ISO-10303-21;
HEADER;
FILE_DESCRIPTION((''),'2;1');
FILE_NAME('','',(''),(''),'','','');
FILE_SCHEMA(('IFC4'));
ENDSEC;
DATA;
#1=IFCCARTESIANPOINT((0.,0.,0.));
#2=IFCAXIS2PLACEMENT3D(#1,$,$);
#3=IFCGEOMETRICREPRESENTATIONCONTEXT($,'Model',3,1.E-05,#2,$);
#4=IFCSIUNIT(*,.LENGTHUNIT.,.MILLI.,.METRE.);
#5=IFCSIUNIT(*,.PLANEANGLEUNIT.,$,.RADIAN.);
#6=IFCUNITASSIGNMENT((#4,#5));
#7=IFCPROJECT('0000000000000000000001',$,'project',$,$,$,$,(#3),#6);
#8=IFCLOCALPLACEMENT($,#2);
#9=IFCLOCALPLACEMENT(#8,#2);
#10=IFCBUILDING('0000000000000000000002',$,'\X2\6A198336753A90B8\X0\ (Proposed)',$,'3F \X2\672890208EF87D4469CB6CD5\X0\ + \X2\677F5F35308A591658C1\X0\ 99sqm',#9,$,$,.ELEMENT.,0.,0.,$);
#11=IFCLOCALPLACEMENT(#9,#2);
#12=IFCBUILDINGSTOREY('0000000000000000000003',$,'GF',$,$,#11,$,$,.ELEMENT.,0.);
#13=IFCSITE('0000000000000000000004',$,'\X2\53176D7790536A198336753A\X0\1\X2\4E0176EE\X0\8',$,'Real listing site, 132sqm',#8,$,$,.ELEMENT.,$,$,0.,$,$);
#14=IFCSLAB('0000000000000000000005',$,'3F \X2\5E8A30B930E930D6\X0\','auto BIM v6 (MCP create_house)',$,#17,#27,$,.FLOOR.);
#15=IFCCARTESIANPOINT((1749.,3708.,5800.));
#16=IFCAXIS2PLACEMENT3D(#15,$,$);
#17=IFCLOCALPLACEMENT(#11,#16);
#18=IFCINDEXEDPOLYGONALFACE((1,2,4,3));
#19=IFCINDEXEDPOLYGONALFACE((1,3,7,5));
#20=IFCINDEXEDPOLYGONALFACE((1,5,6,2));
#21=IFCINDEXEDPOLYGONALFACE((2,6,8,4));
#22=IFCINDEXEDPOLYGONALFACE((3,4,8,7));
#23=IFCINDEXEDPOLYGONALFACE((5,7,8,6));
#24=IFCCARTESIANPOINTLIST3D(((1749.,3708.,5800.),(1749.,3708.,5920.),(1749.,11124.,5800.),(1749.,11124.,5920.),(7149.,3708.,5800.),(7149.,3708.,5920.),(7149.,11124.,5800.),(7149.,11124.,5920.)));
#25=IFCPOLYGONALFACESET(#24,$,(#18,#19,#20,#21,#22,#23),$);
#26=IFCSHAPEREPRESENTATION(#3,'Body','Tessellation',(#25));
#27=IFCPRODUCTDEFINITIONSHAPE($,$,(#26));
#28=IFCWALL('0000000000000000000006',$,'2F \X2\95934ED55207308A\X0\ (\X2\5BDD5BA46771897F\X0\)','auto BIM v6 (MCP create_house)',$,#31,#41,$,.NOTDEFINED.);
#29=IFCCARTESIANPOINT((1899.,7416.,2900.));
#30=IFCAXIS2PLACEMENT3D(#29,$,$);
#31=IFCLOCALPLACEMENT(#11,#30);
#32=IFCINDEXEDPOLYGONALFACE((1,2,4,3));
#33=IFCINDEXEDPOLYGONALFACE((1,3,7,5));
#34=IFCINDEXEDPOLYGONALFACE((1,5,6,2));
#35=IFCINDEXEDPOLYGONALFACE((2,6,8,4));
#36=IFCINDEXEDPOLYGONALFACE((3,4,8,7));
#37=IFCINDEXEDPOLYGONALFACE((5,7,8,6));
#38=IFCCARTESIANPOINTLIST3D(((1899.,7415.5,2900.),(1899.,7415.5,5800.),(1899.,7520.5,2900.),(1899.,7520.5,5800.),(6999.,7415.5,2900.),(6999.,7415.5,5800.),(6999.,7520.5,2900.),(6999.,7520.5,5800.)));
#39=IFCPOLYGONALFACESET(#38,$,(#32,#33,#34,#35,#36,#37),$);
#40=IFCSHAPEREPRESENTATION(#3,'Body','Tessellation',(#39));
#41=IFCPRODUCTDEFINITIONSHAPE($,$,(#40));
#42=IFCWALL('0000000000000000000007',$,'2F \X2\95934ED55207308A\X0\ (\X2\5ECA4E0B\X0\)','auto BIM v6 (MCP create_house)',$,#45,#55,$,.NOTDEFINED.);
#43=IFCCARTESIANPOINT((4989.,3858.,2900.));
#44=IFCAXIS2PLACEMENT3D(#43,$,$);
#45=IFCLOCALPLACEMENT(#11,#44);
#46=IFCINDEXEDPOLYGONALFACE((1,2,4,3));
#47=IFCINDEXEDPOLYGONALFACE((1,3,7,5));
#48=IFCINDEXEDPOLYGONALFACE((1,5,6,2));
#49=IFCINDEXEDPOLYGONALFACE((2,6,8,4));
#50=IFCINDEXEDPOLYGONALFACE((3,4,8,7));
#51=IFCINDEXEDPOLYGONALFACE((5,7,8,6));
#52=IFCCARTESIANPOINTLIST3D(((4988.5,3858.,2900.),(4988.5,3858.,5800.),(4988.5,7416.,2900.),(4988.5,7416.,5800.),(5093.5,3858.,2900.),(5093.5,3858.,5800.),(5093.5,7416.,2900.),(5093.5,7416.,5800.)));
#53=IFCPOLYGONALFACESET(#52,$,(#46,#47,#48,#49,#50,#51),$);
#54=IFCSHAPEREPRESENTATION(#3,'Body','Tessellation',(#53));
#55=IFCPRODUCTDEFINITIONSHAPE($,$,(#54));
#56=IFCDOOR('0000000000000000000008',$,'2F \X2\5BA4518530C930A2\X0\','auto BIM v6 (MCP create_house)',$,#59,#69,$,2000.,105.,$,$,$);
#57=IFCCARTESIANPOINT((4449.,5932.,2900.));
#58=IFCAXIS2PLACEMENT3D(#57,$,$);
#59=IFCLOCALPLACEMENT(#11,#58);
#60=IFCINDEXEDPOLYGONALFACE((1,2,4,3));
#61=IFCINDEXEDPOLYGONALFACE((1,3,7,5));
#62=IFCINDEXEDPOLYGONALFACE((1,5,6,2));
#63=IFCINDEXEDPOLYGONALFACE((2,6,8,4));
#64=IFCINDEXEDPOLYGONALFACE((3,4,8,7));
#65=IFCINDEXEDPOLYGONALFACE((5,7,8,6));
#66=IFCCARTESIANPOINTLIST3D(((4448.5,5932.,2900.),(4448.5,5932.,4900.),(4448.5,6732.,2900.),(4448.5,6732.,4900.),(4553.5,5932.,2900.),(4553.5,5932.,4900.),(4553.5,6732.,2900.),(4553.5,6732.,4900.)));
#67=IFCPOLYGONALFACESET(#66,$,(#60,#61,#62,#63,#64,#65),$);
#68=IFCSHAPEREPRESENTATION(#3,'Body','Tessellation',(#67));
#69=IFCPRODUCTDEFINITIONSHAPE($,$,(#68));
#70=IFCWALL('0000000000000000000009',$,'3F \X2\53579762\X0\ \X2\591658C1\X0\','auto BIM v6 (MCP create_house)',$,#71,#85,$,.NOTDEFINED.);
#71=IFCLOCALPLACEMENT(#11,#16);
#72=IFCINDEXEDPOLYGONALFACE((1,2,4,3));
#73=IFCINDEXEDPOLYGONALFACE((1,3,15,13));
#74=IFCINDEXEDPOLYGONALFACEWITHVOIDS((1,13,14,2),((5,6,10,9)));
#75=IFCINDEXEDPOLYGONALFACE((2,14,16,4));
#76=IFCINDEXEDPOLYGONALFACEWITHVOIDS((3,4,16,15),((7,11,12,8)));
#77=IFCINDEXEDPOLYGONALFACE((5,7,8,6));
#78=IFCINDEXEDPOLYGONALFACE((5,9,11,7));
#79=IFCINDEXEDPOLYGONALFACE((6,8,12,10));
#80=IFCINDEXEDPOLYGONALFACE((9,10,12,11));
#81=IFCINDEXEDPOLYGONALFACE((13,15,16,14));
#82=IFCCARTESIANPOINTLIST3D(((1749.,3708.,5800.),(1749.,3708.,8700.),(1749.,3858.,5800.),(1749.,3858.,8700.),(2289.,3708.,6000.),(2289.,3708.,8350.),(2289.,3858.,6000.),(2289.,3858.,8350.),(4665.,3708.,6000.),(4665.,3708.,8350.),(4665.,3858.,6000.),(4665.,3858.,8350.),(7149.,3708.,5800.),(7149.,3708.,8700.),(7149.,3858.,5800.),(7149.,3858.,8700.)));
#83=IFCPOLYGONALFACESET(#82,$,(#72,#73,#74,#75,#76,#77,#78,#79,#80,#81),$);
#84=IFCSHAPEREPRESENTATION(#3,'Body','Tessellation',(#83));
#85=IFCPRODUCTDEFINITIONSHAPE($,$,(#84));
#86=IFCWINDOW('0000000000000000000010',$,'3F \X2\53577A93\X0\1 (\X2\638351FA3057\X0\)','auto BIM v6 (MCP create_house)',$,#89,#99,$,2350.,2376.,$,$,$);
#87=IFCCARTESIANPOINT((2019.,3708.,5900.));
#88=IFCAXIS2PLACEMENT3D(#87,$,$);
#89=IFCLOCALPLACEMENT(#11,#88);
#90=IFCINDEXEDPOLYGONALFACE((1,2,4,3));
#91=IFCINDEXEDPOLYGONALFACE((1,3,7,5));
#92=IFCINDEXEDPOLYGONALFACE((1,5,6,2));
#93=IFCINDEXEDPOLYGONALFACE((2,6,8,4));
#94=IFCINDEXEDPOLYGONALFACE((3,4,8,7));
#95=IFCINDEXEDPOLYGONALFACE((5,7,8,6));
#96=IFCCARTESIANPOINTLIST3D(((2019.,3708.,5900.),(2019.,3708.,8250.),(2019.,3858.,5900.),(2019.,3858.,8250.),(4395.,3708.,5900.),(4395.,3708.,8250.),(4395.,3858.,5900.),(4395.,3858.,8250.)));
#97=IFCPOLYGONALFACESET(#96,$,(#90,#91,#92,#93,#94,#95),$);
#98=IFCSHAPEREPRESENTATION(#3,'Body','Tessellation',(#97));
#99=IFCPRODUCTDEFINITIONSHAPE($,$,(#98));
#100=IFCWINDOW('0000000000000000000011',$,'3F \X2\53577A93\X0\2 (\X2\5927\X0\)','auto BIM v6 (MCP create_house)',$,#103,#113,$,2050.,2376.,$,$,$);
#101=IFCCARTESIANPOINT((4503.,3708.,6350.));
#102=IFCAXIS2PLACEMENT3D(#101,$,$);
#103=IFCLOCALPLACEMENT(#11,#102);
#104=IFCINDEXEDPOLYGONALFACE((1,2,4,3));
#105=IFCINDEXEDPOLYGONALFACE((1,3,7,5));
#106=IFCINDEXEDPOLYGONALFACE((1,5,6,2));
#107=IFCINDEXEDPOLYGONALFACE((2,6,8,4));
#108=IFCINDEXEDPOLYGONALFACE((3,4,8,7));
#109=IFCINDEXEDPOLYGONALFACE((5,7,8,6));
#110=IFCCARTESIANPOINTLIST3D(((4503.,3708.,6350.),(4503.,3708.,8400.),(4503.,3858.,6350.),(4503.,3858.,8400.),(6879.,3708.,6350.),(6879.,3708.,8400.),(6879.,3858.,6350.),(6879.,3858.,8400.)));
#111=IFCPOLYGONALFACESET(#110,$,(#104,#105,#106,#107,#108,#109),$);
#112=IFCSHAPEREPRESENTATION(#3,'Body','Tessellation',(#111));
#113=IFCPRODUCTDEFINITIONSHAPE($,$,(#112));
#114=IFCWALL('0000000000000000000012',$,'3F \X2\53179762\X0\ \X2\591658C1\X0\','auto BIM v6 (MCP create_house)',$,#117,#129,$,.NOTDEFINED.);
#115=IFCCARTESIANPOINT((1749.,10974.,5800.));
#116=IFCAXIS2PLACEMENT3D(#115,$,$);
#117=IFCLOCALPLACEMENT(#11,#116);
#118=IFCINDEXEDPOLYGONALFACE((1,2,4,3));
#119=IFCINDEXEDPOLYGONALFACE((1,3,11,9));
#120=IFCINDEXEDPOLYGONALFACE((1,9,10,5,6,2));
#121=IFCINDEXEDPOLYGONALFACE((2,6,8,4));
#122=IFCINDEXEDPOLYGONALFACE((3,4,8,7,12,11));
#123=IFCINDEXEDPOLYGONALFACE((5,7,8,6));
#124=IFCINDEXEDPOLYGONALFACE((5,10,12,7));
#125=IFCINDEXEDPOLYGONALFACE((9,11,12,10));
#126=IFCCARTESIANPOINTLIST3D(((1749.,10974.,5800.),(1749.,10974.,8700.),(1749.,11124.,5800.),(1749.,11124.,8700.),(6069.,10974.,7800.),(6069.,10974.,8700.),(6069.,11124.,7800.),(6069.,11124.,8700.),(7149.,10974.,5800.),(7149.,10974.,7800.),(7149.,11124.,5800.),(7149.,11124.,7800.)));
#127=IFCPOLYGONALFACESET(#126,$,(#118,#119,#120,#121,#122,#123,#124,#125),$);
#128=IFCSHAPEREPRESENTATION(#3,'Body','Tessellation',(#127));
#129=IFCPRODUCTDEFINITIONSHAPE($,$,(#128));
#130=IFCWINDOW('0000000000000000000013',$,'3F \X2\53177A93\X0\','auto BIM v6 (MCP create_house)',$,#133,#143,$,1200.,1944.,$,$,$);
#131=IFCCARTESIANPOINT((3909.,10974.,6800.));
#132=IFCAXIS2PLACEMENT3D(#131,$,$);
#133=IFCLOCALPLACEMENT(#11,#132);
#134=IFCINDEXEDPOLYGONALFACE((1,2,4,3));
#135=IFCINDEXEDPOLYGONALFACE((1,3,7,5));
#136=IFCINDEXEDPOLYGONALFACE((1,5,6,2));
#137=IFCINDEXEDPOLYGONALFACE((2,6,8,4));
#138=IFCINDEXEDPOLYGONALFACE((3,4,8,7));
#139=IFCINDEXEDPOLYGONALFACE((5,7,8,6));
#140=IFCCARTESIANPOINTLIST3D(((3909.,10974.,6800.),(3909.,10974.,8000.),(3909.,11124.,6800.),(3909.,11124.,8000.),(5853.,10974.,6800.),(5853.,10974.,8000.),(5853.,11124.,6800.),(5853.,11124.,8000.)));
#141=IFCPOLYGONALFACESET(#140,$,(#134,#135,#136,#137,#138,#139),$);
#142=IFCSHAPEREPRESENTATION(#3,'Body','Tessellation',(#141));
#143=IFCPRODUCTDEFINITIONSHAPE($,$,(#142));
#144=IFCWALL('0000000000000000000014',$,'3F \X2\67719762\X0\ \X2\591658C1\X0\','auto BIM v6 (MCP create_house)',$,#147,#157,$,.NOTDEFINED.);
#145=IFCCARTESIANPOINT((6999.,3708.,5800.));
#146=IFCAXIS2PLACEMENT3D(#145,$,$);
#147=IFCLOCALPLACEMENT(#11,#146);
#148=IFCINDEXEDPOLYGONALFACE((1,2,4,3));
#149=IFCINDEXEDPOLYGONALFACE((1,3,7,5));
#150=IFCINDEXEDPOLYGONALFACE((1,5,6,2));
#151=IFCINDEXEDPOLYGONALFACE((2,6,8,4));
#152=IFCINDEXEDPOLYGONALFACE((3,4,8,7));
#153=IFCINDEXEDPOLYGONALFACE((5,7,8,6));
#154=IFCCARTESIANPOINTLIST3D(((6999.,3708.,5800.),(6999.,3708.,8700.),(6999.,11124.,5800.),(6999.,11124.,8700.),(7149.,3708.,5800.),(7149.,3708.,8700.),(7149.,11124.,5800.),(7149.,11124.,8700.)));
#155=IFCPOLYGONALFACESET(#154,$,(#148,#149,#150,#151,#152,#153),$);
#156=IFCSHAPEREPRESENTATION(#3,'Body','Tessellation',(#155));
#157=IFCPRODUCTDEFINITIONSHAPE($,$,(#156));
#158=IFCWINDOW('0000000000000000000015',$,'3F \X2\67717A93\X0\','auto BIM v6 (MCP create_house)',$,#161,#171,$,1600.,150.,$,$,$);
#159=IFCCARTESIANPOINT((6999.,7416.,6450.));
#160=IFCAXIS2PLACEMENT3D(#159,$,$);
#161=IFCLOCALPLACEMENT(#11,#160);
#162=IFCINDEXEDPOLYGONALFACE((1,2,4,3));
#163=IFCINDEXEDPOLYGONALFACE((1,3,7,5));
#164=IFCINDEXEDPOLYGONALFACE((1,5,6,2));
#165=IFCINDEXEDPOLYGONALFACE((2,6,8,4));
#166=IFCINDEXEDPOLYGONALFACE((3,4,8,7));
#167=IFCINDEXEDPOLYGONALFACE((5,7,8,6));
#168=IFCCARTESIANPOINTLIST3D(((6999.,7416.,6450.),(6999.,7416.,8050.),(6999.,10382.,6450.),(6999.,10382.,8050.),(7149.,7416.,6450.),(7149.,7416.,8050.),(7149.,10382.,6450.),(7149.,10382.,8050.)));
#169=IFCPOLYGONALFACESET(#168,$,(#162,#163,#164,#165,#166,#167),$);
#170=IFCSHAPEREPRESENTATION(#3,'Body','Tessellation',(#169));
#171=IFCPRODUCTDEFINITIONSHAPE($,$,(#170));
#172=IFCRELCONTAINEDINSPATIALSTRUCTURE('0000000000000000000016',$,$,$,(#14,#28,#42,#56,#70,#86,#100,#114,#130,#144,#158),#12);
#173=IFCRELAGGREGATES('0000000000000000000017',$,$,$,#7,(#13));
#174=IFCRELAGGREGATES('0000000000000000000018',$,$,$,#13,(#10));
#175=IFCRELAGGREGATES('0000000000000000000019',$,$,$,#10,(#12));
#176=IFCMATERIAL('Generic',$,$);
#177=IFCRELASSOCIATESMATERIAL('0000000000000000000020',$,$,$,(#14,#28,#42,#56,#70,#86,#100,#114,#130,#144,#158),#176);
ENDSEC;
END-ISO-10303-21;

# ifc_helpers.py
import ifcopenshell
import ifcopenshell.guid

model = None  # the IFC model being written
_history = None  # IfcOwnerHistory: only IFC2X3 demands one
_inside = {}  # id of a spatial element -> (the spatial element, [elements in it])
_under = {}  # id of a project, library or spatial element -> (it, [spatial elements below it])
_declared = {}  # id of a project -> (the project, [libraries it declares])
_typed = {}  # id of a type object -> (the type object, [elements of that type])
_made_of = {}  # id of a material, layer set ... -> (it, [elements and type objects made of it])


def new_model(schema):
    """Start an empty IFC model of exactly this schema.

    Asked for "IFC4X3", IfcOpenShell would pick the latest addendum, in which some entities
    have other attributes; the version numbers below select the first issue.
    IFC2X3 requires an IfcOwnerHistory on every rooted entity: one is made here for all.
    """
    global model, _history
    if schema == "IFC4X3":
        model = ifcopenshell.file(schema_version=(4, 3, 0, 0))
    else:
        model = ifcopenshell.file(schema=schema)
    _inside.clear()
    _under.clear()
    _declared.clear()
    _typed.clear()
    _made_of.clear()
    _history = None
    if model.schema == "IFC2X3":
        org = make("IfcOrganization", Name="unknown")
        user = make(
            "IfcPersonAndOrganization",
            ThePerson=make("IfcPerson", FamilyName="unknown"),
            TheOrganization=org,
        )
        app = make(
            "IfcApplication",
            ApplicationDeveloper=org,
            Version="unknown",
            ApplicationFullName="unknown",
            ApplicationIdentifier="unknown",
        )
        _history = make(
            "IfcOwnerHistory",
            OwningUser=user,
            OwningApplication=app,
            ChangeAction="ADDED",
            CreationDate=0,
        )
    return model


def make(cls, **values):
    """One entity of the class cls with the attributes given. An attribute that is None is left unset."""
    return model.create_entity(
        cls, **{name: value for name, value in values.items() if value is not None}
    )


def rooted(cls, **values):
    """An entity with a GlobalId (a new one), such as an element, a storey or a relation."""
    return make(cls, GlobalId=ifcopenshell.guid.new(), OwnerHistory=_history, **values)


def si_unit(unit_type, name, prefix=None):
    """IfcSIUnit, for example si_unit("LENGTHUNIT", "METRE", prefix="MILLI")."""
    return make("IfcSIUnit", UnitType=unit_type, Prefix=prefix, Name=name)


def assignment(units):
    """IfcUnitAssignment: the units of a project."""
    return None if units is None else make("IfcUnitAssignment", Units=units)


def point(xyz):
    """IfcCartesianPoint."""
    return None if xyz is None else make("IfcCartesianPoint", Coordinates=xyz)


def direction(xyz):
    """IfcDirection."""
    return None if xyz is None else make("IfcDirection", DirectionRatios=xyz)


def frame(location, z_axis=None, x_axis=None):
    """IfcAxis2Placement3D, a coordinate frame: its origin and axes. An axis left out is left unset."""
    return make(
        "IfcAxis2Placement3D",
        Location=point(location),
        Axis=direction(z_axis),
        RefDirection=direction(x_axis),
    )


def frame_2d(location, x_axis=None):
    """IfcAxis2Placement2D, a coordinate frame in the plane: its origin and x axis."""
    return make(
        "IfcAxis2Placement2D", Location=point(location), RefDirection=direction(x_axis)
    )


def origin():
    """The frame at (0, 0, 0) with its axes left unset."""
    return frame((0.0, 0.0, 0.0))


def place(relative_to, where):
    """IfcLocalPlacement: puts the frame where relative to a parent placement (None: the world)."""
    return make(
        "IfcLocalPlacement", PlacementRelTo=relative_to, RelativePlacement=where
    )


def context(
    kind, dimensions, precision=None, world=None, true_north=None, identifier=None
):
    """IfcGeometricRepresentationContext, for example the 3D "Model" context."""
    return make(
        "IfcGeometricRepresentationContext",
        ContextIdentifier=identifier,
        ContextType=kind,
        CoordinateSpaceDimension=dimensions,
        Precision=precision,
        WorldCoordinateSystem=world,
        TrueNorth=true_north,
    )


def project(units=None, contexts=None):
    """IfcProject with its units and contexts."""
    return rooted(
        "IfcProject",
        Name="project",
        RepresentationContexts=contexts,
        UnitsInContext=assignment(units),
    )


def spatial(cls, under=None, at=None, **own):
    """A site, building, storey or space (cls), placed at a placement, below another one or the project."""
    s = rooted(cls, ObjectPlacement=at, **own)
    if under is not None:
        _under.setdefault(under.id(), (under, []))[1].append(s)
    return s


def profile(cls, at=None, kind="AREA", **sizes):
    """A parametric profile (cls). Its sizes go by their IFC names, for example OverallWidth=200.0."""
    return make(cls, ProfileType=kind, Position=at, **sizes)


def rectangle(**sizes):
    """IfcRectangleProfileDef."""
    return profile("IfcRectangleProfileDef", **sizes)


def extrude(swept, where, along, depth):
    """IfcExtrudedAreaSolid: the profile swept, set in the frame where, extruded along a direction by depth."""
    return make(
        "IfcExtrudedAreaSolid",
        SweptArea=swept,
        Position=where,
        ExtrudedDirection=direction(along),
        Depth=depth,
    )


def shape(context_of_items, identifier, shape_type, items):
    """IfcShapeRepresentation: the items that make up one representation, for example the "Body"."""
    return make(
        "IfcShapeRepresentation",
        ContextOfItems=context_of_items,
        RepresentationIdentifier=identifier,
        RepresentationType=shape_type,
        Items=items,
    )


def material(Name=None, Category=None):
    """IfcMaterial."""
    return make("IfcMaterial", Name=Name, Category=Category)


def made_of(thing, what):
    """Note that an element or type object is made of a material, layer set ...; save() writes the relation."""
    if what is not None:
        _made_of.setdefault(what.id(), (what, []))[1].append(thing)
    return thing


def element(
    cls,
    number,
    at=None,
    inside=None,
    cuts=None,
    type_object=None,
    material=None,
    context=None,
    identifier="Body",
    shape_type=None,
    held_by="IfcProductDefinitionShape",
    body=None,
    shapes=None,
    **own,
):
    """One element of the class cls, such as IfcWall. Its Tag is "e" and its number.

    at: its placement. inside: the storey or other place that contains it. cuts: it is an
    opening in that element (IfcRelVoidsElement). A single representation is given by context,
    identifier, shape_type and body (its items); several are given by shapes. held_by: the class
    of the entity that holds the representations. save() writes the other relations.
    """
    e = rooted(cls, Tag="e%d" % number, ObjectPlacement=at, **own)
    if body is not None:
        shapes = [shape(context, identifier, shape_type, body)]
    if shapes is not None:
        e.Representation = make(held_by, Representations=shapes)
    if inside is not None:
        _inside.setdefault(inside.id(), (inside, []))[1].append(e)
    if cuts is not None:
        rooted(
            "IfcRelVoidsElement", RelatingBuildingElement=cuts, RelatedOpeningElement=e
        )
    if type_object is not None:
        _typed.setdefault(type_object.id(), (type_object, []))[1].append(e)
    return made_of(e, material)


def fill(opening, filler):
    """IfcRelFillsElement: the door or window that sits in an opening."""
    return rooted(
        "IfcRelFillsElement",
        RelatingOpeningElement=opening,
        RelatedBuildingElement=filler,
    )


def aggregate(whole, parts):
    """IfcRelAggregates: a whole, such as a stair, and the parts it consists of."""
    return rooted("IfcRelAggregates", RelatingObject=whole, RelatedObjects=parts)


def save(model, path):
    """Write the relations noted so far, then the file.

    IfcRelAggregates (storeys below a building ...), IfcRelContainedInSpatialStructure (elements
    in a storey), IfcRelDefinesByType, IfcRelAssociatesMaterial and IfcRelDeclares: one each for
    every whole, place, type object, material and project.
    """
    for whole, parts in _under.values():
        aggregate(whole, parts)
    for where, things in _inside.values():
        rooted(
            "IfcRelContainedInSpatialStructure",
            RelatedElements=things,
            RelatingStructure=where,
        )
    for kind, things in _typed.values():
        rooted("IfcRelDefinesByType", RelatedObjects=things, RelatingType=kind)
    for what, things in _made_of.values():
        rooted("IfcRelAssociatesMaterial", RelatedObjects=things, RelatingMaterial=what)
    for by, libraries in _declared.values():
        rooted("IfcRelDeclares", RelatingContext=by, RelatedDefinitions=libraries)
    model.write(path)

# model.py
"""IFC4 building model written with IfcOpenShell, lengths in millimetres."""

from ifc_helpers import new_model, si_unit, frame, frame_2d, origin, place, context, project, spatial, rectangle, extrude, material, element, fill, save


model = new_model("IFC4")

# Units and contexts
model_context = context("Model", 3, precision=1e-05, world=origin())
ifc_project = project(units=[si_unit("LENGTHUNIT", "METRE", prefix="MILLI"), si_unit("PLANEANGLEUNIT", "RADIAN")], contexts=[model_context])

# Site, building, storey
site_placement = place(None, origin())
site = spatial("IfcSite", under=ifc_project, at=site_placement, Name="北海道標茶町1丁目8", ObjectType="Real listing site, 132sqm", CompositionType="ELEMENT", RefElevation=0.0)
building_placement = place(site_placement, origin())
building = spatial("IfcBuilding", under=site, at=building_placement, Name="標茶町邸 (Proposed)", ObjectType="3F 木造軸組構法 + 板張り外壁 99sqm", CompositionType="ELEMENT", ElevationOfRefHeight=0.0, ElevationOfTerrain=0.0)
storey_placement = place(building_placement, origin())
storey = spatial("IfcBuildingStorey", under=building, at=storey_placement, Name="GF", CompositionType="ELEMENT", Elevation=0.0)

# Slab
ifc_material = material(Name="Generic")
slab_placement = place(storey_placement, frame((1749.0, 3708.0, 5800.0)))
element("IfcSlab", 1, at=slab_placement, inside=storey, material=ifc_material, Name="3F 床スラブ", Description="auto BIM v6 (MCP create_house)", PredefinedType="FLOOR", context=model_context, shape_type="SweptSolid", body=[
    extrude(rectangle(XDim=5400.0, YDim=7416.0, at=frame_2d((2700.0, 3708.0))), frame((1749.0, 3708.0, 5800.0)), (0.0, 0.0, 1.0), 120.0),
])

# Walls
wall_1_placement = place(storey_placement, frame((1899.0, 7416.0, 2900.0)))
element("IfcWall", 2, at=wall_1_placement, inside=storey, material=ifc_material, Name="2F 間仕切り (寝室東西)", Description="auto BIM v6 (MCP create_house)", PredefinedType="NOTDEFINED", context=model_context, shape_type="SweptSolid", body=[
    extrude(rectangle(XDim=5100.0, YDim=105.0, at=frame_2d((2550.0, 52.0))), frame((1899.0, 7416.0, 2900.0)), (0.0, 0.0, 1.0), 2900.0),
])
wall_2_placement = place(storey_placement, frame((4989.0, 3858.0, 2900.0)))
element("IfcWall", 3, at=wall_2_placement, inside=storey, material=ifc_material, Name="2F 間仕切り (廊下)", Description="auto BIM v6 (MCP create_house)", PredefinedType="NOTDEFINED", context=model_context, shape_type="SweptSolid", body=[
    extrude(rectangle(XDim=105.0, YDim=3558.0, at=frame_2d((52.0, 1779.0))), frame((4989.0, 3858.0, 2900.0)), (0.0, 0.0, 1.0), 2900.0),
])

# Door
door_1_placement = place(storey_placement, frame((4449.0, 5932.0, 2900.0)))
element("IfcDoor", 4, at=door_1_placement, inside=storey, material=ifc_material, Name="2F 室内ドア", Description="auto BIM v6 (MCP create_house)", OverallHeight=2000.0, OverallWidth=105.0, context=model_context, shape_type="SweptSolid", body=[
    extrude(rectangle(XDim=105.0, YDim=800.0, at=frame_2d((52.0, 400.0))), frame((4449.0, 5932.0, 2900.0)), (0.0, 0.0, 1.0), 2000.0),
])

# Wall, openings, windows
wall_3_placement = place(storey_placement, frame((1749.0, 3708.0, 5800.0)))
wall_3 = element("IfcWall", 5, at=wall_3_placement, inside=storey, material=ifc_material, Name="3F 南面 外壁", Description="auto BIM v6 (MCP create_house)", PredefinedType="NOTDEFINED", context=model_context, shape_type="SweptSolid", body=[
    extrude(rectangle(XDim=5400.0, YDim=150.0, at=frame_2d((2700.0, 75.0))), frame((1749.0, 3708.0, 5800.0)), (0.0, 0.0, 1.0), 2900.0),
])
opening_1_placement = place(storey_placement, frame((2019.0, 3708.0, 5900.0)))
opening_1 = element("IfcOpeningElement", 6, at=opening_1_placement, cuts=wall_3, PredefinedType="NOTDEFINED", context=model_context, shape_type="SweptSolid", body=[
    extrude(rectangle(XDim=2376.0, YDim=150.0, at=frame_2d((1188.0, 75.0))), frame((2019.0, 3708.0, 5900.0)), (0.0, 0.0, 1.0), 2350.0),
])
opening_2_placement = place(storey_placement, frame((4503.0, 3708.0, 6350.0)))
opening_2 = element("IfcOpeningElement", 7, at=opening_2_placement, cuts=wall_3, PredefinedType="NOTDEFINED", context=model_context, shape_type="SweptSolid", body=[
    extrude(rectangle(XDim=2376.0, YDim=150.0, at=frame_2d((1188.0, 75.0))), frame((4503.0, 3708.0, 6350.0)), (0.0, 0.0, 1.0), 2050.0),
])
window_1_placement = place(storey_placement, frame((2019.0, 3708.0, 5900.0)))
window_1 = element("IfcWindow", 8, at=window_1_placement, inside=storey, material=ifc_material, Name="3F 南窓1 (掃出し)", Description="auto BIM v6 (MCP create_house)", OverallHeight=2350.0, OverallWidth=2376.0, context=model_context, shape_type="SweptSolid", body=[
    extrude(rectangle(XDim=2376.0, YDim=150.0, at=frame_2d((1188.0, 75.0))), frame((2019.0, 3708.0, 5900.0)), (0.0, 0.0, 1.0), 2350.0),
])
fill(opening_1, window_1)
window_2_placement = place(storey_placement, frame((4503.0, 3708.0, 6350.0)))
window_2 = element("IfcWindow", 9, at=window_2_placement, inside=storey, material=ifc_material, Name="3F 南窓2 (大)", Description="auto BIM v6 (MCP create_house)", OverallHeight=2050.0, OverallWidth=2376.0, context=model_context, shape_type="SweptSolid", body=[
    extrude(rectangle(XDim=2376.0, YDim=150.0, at=frame_2d((1188.0, 75.0))), frame((4503.0, 3708.0, 6350.0)), (0.0, 0.0, 1.0), 2050.0),
])
fill(opening_2, window_2)

# Walls, openings, windows
wall_4_placement = place(storey_placement, frame((1749.0, 10974.0, 5800.0)))
wall_4 = element("IfcWall", 10, at=wall_4_placement, inside=storey, material=ifc_material, Name="3F 北面 外壁", Description="auto BIM v6 (MCP create_house)", PredefinedType="NOTDEFINED", context=model_context, shape_type="SweptSolid", body=[
    extrude(rectangle(XDim=5400.0, YDim=150.0, at=frame_2d((2700.0, 75.0))), frame((1749.0, 10974.0, 5800.0)), (0.0, 0.0, 1.0), 2900.0),
])
opening_3_placement = place(storey_placement, frame((3909.0, 10974.0, 6800.0)))
opening_3 = element("IfcOpeningElement", 11, at=opening_3_placement, cuts=wall_4, PredefinedType="NOTDEFINED", context=model_context, shape_type="SweptSolid", body=[
    extrude(rectangle(XDim=1944.0, YDim=150.0, at=frame_2d((972.0, 75.0))), frame((3909.0, 10974.0, 6800.0)), (0.0, 0.0, 1.0), 1200.0),
])
window_3_placement = place(storey_placement, frame((3909.0, 10974.0, 6800.0)))
window_3 = element("IfcWindow", 12, at=window_3_placement, inside=storey, material=ifc_material, Name="3F 北窓", Description="auto BIM v6 (MCP create_house)", OverallHeight=1200.0, OverallWidth=1944.0, context=model_context, shape_type="SweptSolid", body=[
    extrude(rectangle(XDim=1944.0, YDim=150.0, at=frame_2d((972.0, 75.0))), frame((3909.0, 10974.0, 6800.0)), (0.0, 0.0, 1.0), 1200.0),
])
fill(opening_3, window_3)
wall_5_placement = place(storey_placement, frame((6999.0, 3708.0, 5800.0)))
wall_5 = element("IfcWall", 13, at=wall_5_placement, inside=storey, material=ifc_material, Name="3F 東面 外壁", Description="auto BIM v6 (MCP create_house)", PredefinedType="NOTDEFINED", context=model_context, shape_type="SweptSolid", body=[
    extrude(rectangle(XDim=150.0, YDim=7416.0, at=frame_2d((75.0, 3708.0))), frame((6999.0, 3708.0, 5800.0)), (0.0, 0.0, 1.0), 2900.0),
])
opening_4_placement = place(storey_placement, frame((6999.0, 7416.0, 6450.0)))
opening_4 = element("IfcOpeningElement", 14, at=opening_4_placement, cuts=wall_5, PredefinedType="NOTDEFINED", context=model_context, shape_type="SweptSolid", body=[
    extrude(rectangle(XDim=150.0, YDim=2966.0, at=frame_2d((75.0, 1483.0))), frame((6999.0, 7416.0, 6450.0)), (0.0, 0.0, 1.0), 1600.0),
])
window_4_placement = place(storey_placement, frame((6999.0, 7416.0, 6450.0)))
window_4 = element("IfcWindow", 15, at=window_4_placement, inside=storey, material=ifc_material, Name="3F 東窓", Description="auto BIM v6 (MCP create_house)", OverallHeight=1600.0, OverallWidth=150.0, context=model_context, shape_type="SweptSolid", body=[
    extrude(rectangle(XDim=150.0, YDim=2966.0, at=frame_2d((75.0, 1483.0))), frame((6999.0, 7416.0, 6450.0)), (0.0, 0.0, 1.0), 1600.0),
])
fill(opening_4, window_4)

save(model, "model.ifc")
